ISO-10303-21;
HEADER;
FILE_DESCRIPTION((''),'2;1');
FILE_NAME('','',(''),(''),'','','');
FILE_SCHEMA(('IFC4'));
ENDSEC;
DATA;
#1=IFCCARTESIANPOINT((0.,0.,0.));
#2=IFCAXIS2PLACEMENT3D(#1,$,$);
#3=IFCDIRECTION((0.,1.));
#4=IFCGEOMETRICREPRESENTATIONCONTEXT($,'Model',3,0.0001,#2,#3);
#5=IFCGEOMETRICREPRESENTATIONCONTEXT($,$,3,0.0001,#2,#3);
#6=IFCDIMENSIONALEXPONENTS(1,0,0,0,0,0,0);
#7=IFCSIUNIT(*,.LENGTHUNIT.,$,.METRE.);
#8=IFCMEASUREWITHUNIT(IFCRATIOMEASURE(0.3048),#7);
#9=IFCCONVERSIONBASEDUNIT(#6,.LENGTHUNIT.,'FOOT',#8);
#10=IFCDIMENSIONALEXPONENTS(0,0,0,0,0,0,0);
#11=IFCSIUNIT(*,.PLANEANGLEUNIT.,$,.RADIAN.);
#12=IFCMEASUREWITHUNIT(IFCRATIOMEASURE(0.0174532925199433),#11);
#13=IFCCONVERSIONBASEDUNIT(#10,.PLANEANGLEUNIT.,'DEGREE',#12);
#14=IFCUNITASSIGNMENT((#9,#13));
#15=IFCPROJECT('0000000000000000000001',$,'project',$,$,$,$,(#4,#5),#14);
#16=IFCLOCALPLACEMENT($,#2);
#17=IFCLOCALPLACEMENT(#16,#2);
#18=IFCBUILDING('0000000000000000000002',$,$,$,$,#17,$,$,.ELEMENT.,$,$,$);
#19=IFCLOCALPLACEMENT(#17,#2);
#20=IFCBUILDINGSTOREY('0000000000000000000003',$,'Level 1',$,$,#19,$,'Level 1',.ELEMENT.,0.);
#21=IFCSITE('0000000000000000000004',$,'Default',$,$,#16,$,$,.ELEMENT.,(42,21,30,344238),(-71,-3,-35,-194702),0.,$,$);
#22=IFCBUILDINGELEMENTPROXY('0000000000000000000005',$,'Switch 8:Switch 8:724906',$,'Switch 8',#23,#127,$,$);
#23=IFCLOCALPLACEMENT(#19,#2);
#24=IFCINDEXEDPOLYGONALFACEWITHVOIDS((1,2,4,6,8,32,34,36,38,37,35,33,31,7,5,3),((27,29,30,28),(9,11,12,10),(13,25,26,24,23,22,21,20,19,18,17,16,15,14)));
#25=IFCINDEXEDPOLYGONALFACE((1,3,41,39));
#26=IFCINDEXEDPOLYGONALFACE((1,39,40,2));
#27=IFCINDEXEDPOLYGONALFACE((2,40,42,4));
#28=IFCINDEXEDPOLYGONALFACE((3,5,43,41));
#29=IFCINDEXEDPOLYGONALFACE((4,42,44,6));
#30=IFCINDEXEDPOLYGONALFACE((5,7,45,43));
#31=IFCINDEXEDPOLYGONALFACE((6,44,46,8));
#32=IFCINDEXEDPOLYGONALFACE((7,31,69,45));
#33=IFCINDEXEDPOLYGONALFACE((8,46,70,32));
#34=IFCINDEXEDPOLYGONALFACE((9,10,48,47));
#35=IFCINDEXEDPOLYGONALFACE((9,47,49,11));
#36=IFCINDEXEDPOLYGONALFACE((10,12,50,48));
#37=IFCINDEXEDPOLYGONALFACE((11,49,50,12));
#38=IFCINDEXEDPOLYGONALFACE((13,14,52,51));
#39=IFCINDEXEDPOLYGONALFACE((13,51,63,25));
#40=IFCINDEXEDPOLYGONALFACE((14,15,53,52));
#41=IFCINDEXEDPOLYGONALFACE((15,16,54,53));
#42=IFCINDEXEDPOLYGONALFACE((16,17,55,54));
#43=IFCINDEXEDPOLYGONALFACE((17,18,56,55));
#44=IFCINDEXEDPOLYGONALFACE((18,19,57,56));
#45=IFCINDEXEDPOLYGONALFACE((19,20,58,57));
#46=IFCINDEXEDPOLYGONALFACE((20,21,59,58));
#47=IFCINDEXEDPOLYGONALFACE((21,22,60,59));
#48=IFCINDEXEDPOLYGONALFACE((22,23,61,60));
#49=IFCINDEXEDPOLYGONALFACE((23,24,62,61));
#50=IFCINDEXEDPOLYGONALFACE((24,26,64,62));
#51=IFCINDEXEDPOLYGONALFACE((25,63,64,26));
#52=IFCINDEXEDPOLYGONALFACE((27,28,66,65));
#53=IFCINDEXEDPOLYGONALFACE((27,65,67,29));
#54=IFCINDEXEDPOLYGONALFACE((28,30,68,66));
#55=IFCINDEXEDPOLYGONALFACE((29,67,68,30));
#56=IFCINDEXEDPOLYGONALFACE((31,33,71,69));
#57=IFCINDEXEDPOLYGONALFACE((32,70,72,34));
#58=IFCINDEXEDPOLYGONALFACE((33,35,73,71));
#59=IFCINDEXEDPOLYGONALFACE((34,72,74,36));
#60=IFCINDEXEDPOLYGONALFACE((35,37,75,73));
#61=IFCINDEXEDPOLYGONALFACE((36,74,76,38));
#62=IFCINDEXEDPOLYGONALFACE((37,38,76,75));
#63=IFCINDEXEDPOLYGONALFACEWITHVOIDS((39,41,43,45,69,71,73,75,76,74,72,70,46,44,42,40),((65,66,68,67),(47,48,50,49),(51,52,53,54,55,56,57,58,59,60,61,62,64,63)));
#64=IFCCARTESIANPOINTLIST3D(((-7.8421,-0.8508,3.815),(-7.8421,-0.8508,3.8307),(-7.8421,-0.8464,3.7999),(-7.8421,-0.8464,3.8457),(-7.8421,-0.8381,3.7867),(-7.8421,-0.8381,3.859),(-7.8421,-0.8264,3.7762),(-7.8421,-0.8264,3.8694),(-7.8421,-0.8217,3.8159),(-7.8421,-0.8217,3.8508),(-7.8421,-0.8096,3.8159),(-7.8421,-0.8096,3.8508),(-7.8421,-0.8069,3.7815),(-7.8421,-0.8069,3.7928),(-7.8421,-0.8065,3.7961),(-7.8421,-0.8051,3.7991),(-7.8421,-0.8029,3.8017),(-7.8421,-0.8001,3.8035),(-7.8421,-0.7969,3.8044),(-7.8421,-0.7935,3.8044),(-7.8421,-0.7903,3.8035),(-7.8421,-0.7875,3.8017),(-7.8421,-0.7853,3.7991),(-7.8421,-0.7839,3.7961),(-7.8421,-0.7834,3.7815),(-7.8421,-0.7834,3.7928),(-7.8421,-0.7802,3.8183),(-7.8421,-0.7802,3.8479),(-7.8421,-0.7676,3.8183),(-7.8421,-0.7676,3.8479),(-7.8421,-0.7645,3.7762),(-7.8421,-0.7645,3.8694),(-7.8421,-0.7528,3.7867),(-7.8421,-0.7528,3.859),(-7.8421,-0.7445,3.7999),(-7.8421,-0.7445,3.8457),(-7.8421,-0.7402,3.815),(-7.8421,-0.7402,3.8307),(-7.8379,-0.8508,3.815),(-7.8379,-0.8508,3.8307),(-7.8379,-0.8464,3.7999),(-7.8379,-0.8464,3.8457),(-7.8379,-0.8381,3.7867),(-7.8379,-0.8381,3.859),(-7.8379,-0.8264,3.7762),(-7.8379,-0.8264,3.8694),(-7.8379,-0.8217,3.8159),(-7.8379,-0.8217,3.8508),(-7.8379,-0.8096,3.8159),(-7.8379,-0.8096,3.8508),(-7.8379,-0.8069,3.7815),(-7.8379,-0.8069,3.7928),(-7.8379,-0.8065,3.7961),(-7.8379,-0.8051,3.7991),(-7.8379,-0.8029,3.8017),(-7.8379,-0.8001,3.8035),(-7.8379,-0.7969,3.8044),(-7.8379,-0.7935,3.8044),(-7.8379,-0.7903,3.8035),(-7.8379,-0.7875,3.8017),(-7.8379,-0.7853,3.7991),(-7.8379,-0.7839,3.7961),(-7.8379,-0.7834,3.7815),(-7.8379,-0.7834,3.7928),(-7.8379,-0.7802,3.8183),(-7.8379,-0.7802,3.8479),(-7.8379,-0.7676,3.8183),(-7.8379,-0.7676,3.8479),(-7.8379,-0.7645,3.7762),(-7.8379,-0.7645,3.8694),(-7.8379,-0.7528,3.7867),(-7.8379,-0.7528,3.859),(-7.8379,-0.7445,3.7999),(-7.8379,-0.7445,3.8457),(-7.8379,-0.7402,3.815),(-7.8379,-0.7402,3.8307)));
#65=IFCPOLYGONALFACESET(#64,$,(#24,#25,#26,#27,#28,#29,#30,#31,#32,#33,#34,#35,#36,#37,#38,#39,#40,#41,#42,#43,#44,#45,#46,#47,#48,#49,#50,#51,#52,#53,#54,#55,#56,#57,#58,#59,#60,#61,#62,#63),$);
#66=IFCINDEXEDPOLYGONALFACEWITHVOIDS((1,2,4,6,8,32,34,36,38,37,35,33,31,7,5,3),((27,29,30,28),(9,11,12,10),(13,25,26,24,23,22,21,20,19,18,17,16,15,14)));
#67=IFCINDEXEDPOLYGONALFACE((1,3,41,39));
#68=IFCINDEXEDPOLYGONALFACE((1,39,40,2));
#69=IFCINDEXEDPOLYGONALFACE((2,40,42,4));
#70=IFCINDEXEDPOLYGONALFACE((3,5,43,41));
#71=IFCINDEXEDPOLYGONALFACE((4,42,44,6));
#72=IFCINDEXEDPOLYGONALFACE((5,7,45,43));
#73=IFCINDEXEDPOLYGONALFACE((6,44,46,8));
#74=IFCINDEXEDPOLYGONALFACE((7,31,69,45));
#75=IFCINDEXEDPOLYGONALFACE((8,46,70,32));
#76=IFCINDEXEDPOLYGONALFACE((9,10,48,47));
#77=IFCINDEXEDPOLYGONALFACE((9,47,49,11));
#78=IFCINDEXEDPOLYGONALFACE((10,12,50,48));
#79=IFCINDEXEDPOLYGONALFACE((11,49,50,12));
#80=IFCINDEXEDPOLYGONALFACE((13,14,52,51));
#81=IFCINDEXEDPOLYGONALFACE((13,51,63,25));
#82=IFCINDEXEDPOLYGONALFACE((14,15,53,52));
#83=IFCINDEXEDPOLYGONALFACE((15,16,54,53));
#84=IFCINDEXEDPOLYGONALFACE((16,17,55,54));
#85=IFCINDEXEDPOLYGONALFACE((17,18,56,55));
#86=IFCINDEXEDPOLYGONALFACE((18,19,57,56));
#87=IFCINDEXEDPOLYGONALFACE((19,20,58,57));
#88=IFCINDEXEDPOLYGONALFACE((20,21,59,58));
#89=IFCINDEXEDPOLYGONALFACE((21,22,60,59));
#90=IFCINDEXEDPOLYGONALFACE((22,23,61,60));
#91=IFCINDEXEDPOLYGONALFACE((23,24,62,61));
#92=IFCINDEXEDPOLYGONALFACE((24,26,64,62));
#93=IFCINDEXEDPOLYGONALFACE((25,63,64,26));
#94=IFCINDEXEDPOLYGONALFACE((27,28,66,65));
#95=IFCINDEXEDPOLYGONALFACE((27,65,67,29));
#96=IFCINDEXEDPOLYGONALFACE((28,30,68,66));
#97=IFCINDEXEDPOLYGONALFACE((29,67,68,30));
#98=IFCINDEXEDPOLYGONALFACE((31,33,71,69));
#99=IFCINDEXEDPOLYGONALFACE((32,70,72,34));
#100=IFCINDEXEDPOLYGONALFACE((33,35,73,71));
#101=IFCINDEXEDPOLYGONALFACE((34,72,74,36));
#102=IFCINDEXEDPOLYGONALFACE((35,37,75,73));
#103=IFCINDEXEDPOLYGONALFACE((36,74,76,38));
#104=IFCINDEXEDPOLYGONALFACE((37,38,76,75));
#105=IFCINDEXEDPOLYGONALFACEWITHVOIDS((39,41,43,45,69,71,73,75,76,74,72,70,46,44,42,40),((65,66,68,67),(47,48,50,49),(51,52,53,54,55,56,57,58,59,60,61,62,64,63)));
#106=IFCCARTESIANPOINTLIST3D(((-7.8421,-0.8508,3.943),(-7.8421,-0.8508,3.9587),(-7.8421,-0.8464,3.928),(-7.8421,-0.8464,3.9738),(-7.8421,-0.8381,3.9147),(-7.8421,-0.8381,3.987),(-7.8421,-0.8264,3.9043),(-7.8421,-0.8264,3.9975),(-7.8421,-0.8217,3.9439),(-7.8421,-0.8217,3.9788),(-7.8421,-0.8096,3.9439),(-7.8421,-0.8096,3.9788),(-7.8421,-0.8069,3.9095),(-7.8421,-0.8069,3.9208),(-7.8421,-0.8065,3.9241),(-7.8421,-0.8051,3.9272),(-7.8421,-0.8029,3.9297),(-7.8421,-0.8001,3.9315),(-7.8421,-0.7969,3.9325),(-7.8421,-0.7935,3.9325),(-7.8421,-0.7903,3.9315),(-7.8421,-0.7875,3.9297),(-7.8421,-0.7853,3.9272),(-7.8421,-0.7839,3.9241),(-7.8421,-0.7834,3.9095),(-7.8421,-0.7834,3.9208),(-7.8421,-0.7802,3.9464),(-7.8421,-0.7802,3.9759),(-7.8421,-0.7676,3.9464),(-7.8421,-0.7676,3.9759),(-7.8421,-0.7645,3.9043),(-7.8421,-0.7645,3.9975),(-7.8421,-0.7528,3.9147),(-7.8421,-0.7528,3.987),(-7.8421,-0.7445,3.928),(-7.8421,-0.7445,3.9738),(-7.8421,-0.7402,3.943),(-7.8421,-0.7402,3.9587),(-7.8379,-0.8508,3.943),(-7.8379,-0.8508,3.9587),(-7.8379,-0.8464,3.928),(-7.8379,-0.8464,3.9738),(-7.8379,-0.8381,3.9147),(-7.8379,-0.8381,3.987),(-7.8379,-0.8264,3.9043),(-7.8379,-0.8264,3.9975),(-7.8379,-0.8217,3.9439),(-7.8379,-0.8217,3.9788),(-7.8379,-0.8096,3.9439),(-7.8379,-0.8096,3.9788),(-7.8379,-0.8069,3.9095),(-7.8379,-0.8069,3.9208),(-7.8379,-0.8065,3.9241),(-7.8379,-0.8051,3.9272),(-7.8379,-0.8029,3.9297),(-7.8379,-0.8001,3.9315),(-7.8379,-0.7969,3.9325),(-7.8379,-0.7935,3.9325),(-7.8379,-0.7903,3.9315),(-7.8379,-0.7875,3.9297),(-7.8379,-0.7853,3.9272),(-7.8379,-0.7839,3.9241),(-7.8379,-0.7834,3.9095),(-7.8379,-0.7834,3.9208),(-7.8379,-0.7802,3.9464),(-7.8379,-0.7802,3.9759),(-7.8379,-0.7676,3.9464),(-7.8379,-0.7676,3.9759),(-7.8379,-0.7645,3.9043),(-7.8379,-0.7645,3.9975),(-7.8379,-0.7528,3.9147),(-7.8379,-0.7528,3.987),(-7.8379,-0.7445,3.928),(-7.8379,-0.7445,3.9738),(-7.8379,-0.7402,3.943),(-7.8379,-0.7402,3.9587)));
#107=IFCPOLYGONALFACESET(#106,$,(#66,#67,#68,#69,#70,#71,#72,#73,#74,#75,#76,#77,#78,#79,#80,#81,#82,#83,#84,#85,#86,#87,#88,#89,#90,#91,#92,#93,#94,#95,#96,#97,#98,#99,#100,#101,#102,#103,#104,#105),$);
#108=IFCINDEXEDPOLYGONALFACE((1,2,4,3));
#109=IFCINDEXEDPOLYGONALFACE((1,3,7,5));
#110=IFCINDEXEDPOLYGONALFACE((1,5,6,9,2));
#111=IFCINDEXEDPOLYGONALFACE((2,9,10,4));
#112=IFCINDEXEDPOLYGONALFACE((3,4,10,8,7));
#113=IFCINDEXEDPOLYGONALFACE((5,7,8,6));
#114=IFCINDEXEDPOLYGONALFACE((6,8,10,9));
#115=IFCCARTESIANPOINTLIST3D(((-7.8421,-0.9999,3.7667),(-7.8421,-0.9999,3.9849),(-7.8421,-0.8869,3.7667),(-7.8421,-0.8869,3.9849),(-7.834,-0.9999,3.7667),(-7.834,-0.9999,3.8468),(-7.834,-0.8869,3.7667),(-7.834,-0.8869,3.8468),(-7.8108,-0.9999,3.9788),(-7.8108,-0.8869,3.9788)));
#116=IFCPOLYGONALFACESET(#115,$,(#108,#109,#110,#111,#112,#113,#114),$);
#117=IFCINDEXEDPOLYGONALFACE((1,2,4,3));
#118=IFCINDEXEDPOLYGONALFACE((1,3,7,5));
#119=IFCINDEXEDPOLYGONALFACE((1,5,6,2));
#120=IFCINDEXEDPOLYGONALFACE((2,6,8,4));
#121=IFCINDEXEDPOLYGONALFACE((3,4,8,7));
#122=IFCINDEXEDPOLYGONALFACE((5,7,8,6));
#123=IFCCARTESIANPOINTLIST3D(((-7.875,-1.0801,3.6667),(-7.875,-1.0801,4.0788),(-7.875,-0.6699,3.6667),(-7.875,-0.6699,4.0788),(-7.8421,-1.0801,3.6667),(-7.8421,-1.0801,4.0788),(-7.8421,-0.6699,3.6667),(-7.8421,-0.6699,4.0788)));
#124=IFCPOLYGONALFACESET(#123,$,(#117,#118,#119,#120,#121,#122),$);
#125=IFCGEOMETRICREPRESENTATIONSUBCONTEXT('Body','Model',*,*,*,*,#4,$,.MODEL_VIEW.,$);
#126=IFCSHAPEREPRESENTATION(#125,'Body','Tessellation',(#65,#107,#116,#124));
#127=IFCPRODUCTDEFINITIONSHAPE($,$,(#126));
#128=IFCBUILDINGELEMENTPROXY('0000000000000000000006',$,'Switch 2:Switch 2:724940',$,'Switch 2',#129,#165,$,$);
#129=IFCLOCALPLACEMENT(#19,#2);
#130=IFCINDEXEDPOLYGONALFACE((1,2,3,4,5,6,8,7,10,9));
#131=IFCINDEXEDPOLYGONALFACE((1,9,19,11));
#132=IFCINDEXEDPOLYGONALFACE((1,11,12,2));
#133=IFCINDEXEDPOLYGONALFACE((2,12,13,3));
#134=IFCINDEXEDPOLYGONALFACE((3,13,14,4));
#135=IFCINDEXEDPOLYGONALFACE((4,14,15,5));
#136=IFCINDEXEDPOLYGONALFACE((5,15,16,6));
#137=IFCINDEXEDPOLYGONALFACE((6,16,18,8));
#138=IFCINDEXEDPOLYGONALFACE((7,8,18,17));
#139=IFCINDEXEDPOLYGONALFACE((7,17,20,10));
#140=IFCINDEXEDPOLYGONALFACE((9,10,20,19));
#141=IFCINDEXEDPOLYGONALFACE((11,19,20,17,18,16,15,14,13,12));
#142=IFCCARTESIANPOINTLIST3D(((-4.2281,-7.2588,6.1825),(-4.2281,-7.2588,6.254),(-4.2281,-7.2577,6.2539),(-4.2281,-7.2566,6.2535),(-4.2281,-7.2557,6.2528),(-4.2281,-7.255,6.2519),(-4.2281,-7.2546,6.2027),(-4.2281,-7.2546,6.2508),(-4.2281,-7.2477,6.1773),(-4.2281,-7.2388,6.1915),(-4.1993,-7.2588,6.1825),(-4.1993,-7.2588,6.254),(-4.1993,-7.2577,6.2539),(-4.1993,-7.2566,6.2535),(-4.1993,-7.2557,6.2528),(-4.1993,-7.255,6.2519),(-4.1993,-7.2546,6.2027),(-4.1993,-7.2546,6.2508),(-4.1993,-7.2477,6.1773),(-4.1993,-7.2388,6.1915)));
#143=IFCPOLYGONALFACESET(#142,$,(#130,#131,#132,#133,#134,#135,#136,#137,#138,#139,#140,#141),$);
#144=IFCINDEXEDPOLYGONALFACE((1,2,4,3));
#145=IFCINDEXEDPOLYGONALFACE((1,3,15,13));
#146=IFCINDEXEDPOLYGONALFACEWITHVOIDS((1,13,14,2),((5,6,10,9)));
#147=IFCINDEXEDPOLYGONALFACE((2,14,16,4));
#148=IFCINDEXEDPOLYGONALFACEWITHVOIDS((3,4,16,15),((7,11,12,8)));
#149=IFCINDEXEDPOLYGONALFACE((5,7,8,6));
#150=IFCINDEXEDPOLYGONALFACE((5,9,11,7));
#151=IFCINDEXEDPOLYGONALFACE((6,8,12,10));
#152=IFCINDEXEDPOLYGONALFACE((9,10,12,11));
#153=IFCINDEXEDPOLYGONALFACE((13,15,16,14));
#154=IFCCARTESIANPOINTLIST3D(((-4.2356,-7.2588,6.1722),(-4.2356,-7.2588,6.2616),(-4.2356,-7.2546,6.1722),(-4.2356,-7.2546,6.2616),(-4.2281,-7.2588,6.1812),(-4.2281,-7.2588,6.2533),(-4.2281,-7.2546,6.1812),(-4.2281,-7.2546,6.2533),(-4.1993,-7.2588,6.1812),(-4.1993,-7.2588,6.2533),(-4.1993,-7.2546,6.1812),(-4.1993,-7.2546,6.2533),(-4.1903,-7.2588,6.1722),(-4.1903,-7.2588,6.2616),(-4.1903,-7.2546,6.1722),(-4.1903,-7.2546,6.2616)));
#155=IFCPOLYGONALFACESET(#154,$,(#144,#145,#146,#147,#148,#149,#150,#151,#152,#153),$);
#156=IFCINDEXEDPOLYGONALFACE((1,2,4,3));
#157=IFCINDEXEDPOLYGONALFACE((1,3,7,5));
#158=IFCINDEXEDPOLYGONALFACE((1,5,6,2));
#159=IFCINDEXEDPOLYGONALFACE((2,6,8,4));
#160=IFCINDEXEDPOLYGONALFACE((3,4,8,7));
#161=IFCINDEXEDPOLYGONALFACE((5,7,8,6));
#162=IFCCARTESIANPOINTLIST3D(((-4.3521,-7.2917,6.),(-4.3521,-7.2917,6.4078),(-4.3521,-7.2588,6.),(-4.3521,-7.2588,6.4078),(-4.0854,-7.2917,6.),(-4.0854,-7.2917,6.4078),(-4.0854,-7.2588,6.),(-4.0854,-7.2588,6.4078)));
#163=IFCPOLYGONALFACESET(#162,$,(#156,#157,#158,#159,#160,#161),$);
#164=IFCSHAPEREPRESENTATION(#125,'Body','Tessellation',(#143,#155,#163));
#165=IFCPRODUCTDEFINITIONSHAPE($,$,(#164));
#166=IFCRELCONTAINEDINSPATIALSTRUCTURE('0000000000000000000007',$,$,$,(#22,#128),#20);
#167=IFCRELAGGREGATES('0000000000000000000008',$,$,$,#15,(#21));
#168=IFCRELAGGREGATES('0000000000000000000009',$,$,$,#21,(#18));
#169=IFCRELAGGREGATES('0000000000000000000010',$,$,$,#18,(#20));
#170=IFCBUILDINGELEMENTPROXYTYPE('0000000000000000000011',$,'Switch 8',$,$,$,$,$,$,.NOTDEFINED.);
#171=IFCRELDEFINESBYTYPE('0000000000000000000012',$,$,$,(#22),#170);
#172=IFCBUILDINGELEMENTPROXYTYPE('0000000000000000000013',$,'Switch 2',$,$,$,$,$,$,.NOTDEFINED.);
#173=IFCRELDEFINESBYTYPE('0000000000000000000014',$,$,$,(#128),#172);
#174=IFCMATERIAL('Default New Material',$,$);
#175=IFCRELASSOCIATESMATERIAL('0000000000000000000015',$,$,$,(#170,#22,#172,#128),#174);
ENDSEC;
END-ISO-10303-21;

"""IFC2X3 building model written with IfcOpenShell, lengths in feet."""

from ifc_helpers import new_model, entity, si_unit, converted_unit, direction, frame, frame_2d, origin, origin_2d_with_axis, place, context, subcontext, project, spatial, polyline, circle_curve, parameter, trimmed, segment, composite_curve, rectangle, outline, extrude, source, transform, mapped, material, type_object, type_shapes, element, save


model = new_model("IFC2X3")

# Units and contexts
model_context = context("Model", 3, precision=0.0001, world=origin(), true_north=direction((0.0, 1.0)))
context_of_model = context(None, 3, precision=0.0001, world=origin(), true_north=direction((0.0, 1.0)))
body_context = subcontext(model_context, "Body", "Model", "MODEL_VIEW")
ifc_project = project(units=[converted_unit("LENGTHUNIT", "FOOT", entity("IfcRatioMeasure", 0.3048), si_unit("LENGTHUNIT", "METRE"), dimensions=[1, 0, 0, 0, 0, 0, 0]), converted_unit("PLANEANGLEUNIT", "DEGREE", entity("IfcRatioMeasure", 0.0174532925199433), si_unit("PLANEANGLEUNIT", "RADIAN"), dimensions=[0, 0, 0, 0, 0, 0, 0])], contexts=[model_context, context_of_model])

# Site, building, storey
site_placement = place(None, origin())
site = spatial("IfcSite", under=ifc_project, at=site_placement, Name="Default", CompositionType="ELEMENT", RefLatitude=(42, 21, 30, 344238), RefLongitude=(-71, -3, -35, -194702), RefElevation=0.0)
building_placement = place(site_placement, origin())
building = spatial("IfcBuilding", under=site, at=building_placement, CompositionType="ELEMENT")
storey_placement = place(building_placement, origin())
storey = spatial("IfcBuildingStorey", under=building, at=storey_placement, Name="Level 1", LongName="Level 1", CompositionType="ELEMENT", Elevation=0.0)

# Shared definitions
ifc_material = material(Name="Default New Material")

# Building element proxies
building_element_proxy_type_1 = type_object("IfcBuildingElementProxyType", Name="Switch 8", PredefinedType="NOTDEFINED", material=ifc_material)
shared_shape_1 = source(origin(), body_context, "Body", "SweptSolid", [
    extrude(outline(composite_curve([segment(trimmed(circle_curve(frame_2d((0.0003, 0.0), x_axis=(1.0, 0.0)), 0.0561), [parameter(123.794741)], [parameter(236.205259)], True, "PARAMETER"), True, "CONTINUOUS"), segment(polyline([(-0.0309, -0.0466), (0.0309, -0.0466)]), True, "CONTINUOUS"), segment(trimmed(circle_curve(frame_2d((-0.0003, 0.0), x_axis=(-1.0, 0.0)), 0.0561), [parameter(123.794741)], [parameter(236.205259)], True, "PARAMETER"), True, "CONTINUOUS"), segment(polyline([(0.0309, 0.0466), (-0.0309, 0.0466)]), True, "CONTINUOUS")], self_intersect=False), holes=[polyline([(0.0142, -0.0279), (0.0142, 0.0069), (0.0262, 0.0069), (0.0262, -0.0279), (0.0142, -0.0279)]), polyline([(-0.0153, -0.0251), (-0.0278, -0.0251), (-0.0278, 0.0045), (-0.0153, 0.0045), (-0.0153, -0.0251)]), composite_curve([segment(polyline([(-0.012, 0.0414), (0.0115, 0.0414)]), True, "CONTINUOUS"), segment(polyline([(0.0115, 0.0414), (0.0115, 0.03)]), True, "CONTINUOUS"), segment(trimmed(circle_curve(frame_2d((-0.0003, 0.03), x_axis=(-1.0, 0.0)), 0.0118), [parameter(0.0)], [parameter(180.0)], True, "PARAMETER"), False, "CONTINUOUS"), segment(polyline([(-0.012, 0.03), (-0.012, 0.0414)]), True, "CONTINUOUS")], self_intersect=False)]), frame((-0.0795, 0.0329, 0.1562), z_axis=(0.0, 1.0, 0.0), x_axis=(1.0, 0.0, 0.0)), (0.0, 0.0, 1.0), 0.0042),
    extrude(outline(composite_curve([segment(trimmed(circle_curve(frame_2d((0.0003, 0.0), x_axis=(1.0, 0.0)), 0.0561), [parameter(123.794741)], [parameter(236.205259)], True, "PARAMETER"), True, "CONTINUOUS"), segment(polyline([(-0.0309, -0.0466), (0.0309, -0.0466)]), True, "CONTINUOUS"), segment(trimmed(circle_curve(frame_2d((-0.0003, 0.0), x_axis=(-1.0, 0.0)), 0.0561), [parameter(123.794741)], [parameter(236.205259)], True, "PARAMETER"), True, "CONTINUOUS"), segment(polyline([(0.0309, 0.0466), (-0.0309, 0.0466)]), True, "CONTINUOUS")], self_intersect=False), holes=[polyline([(0.0142, -0.0279), (0.0142, 0.0069), (0.0262, 0.0069), (0.0262, -0.0279), (0.0142, -0.0279)]), polyline([(-0.0153, -0.0251), (-0.0278, -0.0251), (-0.0278, 0.0045), (-0.0153, 0.0045), (-0.0153, -0.0251)]), composite_curve([segment(polyline([(-0.012, 0.0414), (0.0115, 0.0414)]), True, "CONTINUOUS"), segment(polyline([(0.0115, 0.0414), (0.0115, 0.03)]), True, "CONTINUOUS"), segment(trimmed(circle_curve(frame_2d((-0.0003, 0.03), x_axis=(-1.0, 0.0)), 0.0118), [parameter(0.0)], [parameter(180.0)], True, "PARAMETER"), False, "CONTINUOUS"), segment(polyline([(-0.012, 0.03), (-0.012, 0.0414)]), True, "CONTINUOUS")], self_intersect=False)]), frame((-0.0795, 0.0329, 0.2842), z_axis=(0.0, 1.0, 0.0), x_axis=(1.0, 0.0, 0.0)), (0.0, 0.0, 1.0), 0.0042),
    extrude(outline(polyline([(-0.1161, -0.0095), (0.1021, -0.0095), (0.1021, -0.0014), (0.0219, -0.0014), (-0.11, 0.0219), (-0.1161, -0.0095)])), frame((0.0119, 0.0424, 0.2021), z_axis=(1.0, 0.0, 0.0), x_axis=(0.0, 0.0, -1.0)), (0.0, 0.0, 1.0), 0.1129),
    extrude(rectangle(XDim=0.0329, YDim=0.4101, at=origin_2d_with_axis()), frame((0.0, 0.0164, 0.0), z_axis=(0.0, 0.0, 1.0), x_axis=(0.0, -1.0, 0.0)), (0.0, 0.0, 1.0), 0.4121),
])
type_shapes(building_element_proxy_type_1, [shared_shape_1])
proxy_1_placement = place(storey_placement, frame((-7.875, -0.875, 3.6667), z_axis=(0.0, 0.0, 1.0), x_axis=(0.0, -1.0, 0.0)))
element("IfcBuildingElementProxy", 1, at=proxy_1_placement, inside=storey, type_object=building_element_proxy_type_1, material=ifc_material, Name="Switch 8:Switch 8:724906", ObjectType="Switch 8", context=body_context, shape_type="MappedRepresentation", body=[
    mapped(shared_shape_1, transform((0.0, 0.0, 0.0), scale=1.0)),
])
building_element_proxy_type_2 = type_object("IfcBuildingElementProxyType", Name="Switch 2", PredefinedType="NOTDEFINED", material=ifc_material)
shared_shape_2 = source(origin(), body_context, "Body", "SweptSolid", [
    extrude(outline(composite_curve([segment(polyline([(-0.0252, -0.0211), (-0.0084, -0.0211)]), True, "CONTINUOUS"), segment(polyline([(-0.0084, -0.0211), (-0.0073, -0.0017)]), True, "CONTINUOUS"), segment(polyline([(-0.0073, -0.0017), (0.0336, 0.0237)]), True, "CONTINUOUS"), segment(trimmed(circle_curve(frame_2d((0.0308, 0.0266), x_axis=(0.848706, 0.528865)), 0.004), [parameter(281.689503)], [parameter(4.471238)], True, "PARAMETER"), True, "CONTINUOUS"), segment(polyline([(0.034, 0.029), (-0.0267, -0.0088)]), True, "CONTINUOUS"), segment(polyline([(-0.0267, -0.0088), (-0.0252, -0.0211)]), True, "CONTINUOUS")], self_intersect=False)), frame((-0.0093, 0.0394, 0.2098), z_axis=(1.0, 0.0, 0.0), x_axis=(0.0, 0.528865, 0.848706)), (0.0, 0.0, 1.0), 0.0287),
    extrude(outline(polyline([(-0.0447, -0.0227), (0.0447, -0.0227), (0.0447, 0.0227), (-0.0447, 0.0227), (-0.0447, -0.0227)]), holes=[polyline([(-0.0364, -0.0136), (-0.0364, 0.0151), (0.0357, 0.0151), (0.0357, -0.0136), (-0.0364, -0.0136)])]), frame((0.0058, 0.0328, 0.2169), z_axis=(0.0, 1.0, 0.0), x_axis=(0.0, 0.0, -1.0)), (0.0, 0.0, 1.0), 0.0042),
    extrude(rectangle(XDim=0.0328, YDim=0.2667, at=origin_2d_with_axis()), frame((0.0, 0.0164, 0.0), z_axis=(0.0, 0.0, 1.0), x_axis=(0.0, -1.0, 0.0)), (0.0, 0.0, 1.0), 0.4078),
])
type_shapes(building_element_proxy_type_2, [shared_shape_2])
proxy_2_placement = place(storey_placement, frame((-4.2187, -7.2917, 6.0)))
element("IfcBuildingElementProxy", 2, at=proxy_2_placement, inside=storey, type_object=building_element_proxy_type_2, material=ifc_material, Name="Switch 2:Switch 2:724940", ObjectType="Switch 2", context=body_context, shape_type="MappedRepresentation", body=[
    mapped(shared_shape_2, transform((0.0, 0.0, 0.0), scale=1.0)),
])

save(model, "model.ifc")
